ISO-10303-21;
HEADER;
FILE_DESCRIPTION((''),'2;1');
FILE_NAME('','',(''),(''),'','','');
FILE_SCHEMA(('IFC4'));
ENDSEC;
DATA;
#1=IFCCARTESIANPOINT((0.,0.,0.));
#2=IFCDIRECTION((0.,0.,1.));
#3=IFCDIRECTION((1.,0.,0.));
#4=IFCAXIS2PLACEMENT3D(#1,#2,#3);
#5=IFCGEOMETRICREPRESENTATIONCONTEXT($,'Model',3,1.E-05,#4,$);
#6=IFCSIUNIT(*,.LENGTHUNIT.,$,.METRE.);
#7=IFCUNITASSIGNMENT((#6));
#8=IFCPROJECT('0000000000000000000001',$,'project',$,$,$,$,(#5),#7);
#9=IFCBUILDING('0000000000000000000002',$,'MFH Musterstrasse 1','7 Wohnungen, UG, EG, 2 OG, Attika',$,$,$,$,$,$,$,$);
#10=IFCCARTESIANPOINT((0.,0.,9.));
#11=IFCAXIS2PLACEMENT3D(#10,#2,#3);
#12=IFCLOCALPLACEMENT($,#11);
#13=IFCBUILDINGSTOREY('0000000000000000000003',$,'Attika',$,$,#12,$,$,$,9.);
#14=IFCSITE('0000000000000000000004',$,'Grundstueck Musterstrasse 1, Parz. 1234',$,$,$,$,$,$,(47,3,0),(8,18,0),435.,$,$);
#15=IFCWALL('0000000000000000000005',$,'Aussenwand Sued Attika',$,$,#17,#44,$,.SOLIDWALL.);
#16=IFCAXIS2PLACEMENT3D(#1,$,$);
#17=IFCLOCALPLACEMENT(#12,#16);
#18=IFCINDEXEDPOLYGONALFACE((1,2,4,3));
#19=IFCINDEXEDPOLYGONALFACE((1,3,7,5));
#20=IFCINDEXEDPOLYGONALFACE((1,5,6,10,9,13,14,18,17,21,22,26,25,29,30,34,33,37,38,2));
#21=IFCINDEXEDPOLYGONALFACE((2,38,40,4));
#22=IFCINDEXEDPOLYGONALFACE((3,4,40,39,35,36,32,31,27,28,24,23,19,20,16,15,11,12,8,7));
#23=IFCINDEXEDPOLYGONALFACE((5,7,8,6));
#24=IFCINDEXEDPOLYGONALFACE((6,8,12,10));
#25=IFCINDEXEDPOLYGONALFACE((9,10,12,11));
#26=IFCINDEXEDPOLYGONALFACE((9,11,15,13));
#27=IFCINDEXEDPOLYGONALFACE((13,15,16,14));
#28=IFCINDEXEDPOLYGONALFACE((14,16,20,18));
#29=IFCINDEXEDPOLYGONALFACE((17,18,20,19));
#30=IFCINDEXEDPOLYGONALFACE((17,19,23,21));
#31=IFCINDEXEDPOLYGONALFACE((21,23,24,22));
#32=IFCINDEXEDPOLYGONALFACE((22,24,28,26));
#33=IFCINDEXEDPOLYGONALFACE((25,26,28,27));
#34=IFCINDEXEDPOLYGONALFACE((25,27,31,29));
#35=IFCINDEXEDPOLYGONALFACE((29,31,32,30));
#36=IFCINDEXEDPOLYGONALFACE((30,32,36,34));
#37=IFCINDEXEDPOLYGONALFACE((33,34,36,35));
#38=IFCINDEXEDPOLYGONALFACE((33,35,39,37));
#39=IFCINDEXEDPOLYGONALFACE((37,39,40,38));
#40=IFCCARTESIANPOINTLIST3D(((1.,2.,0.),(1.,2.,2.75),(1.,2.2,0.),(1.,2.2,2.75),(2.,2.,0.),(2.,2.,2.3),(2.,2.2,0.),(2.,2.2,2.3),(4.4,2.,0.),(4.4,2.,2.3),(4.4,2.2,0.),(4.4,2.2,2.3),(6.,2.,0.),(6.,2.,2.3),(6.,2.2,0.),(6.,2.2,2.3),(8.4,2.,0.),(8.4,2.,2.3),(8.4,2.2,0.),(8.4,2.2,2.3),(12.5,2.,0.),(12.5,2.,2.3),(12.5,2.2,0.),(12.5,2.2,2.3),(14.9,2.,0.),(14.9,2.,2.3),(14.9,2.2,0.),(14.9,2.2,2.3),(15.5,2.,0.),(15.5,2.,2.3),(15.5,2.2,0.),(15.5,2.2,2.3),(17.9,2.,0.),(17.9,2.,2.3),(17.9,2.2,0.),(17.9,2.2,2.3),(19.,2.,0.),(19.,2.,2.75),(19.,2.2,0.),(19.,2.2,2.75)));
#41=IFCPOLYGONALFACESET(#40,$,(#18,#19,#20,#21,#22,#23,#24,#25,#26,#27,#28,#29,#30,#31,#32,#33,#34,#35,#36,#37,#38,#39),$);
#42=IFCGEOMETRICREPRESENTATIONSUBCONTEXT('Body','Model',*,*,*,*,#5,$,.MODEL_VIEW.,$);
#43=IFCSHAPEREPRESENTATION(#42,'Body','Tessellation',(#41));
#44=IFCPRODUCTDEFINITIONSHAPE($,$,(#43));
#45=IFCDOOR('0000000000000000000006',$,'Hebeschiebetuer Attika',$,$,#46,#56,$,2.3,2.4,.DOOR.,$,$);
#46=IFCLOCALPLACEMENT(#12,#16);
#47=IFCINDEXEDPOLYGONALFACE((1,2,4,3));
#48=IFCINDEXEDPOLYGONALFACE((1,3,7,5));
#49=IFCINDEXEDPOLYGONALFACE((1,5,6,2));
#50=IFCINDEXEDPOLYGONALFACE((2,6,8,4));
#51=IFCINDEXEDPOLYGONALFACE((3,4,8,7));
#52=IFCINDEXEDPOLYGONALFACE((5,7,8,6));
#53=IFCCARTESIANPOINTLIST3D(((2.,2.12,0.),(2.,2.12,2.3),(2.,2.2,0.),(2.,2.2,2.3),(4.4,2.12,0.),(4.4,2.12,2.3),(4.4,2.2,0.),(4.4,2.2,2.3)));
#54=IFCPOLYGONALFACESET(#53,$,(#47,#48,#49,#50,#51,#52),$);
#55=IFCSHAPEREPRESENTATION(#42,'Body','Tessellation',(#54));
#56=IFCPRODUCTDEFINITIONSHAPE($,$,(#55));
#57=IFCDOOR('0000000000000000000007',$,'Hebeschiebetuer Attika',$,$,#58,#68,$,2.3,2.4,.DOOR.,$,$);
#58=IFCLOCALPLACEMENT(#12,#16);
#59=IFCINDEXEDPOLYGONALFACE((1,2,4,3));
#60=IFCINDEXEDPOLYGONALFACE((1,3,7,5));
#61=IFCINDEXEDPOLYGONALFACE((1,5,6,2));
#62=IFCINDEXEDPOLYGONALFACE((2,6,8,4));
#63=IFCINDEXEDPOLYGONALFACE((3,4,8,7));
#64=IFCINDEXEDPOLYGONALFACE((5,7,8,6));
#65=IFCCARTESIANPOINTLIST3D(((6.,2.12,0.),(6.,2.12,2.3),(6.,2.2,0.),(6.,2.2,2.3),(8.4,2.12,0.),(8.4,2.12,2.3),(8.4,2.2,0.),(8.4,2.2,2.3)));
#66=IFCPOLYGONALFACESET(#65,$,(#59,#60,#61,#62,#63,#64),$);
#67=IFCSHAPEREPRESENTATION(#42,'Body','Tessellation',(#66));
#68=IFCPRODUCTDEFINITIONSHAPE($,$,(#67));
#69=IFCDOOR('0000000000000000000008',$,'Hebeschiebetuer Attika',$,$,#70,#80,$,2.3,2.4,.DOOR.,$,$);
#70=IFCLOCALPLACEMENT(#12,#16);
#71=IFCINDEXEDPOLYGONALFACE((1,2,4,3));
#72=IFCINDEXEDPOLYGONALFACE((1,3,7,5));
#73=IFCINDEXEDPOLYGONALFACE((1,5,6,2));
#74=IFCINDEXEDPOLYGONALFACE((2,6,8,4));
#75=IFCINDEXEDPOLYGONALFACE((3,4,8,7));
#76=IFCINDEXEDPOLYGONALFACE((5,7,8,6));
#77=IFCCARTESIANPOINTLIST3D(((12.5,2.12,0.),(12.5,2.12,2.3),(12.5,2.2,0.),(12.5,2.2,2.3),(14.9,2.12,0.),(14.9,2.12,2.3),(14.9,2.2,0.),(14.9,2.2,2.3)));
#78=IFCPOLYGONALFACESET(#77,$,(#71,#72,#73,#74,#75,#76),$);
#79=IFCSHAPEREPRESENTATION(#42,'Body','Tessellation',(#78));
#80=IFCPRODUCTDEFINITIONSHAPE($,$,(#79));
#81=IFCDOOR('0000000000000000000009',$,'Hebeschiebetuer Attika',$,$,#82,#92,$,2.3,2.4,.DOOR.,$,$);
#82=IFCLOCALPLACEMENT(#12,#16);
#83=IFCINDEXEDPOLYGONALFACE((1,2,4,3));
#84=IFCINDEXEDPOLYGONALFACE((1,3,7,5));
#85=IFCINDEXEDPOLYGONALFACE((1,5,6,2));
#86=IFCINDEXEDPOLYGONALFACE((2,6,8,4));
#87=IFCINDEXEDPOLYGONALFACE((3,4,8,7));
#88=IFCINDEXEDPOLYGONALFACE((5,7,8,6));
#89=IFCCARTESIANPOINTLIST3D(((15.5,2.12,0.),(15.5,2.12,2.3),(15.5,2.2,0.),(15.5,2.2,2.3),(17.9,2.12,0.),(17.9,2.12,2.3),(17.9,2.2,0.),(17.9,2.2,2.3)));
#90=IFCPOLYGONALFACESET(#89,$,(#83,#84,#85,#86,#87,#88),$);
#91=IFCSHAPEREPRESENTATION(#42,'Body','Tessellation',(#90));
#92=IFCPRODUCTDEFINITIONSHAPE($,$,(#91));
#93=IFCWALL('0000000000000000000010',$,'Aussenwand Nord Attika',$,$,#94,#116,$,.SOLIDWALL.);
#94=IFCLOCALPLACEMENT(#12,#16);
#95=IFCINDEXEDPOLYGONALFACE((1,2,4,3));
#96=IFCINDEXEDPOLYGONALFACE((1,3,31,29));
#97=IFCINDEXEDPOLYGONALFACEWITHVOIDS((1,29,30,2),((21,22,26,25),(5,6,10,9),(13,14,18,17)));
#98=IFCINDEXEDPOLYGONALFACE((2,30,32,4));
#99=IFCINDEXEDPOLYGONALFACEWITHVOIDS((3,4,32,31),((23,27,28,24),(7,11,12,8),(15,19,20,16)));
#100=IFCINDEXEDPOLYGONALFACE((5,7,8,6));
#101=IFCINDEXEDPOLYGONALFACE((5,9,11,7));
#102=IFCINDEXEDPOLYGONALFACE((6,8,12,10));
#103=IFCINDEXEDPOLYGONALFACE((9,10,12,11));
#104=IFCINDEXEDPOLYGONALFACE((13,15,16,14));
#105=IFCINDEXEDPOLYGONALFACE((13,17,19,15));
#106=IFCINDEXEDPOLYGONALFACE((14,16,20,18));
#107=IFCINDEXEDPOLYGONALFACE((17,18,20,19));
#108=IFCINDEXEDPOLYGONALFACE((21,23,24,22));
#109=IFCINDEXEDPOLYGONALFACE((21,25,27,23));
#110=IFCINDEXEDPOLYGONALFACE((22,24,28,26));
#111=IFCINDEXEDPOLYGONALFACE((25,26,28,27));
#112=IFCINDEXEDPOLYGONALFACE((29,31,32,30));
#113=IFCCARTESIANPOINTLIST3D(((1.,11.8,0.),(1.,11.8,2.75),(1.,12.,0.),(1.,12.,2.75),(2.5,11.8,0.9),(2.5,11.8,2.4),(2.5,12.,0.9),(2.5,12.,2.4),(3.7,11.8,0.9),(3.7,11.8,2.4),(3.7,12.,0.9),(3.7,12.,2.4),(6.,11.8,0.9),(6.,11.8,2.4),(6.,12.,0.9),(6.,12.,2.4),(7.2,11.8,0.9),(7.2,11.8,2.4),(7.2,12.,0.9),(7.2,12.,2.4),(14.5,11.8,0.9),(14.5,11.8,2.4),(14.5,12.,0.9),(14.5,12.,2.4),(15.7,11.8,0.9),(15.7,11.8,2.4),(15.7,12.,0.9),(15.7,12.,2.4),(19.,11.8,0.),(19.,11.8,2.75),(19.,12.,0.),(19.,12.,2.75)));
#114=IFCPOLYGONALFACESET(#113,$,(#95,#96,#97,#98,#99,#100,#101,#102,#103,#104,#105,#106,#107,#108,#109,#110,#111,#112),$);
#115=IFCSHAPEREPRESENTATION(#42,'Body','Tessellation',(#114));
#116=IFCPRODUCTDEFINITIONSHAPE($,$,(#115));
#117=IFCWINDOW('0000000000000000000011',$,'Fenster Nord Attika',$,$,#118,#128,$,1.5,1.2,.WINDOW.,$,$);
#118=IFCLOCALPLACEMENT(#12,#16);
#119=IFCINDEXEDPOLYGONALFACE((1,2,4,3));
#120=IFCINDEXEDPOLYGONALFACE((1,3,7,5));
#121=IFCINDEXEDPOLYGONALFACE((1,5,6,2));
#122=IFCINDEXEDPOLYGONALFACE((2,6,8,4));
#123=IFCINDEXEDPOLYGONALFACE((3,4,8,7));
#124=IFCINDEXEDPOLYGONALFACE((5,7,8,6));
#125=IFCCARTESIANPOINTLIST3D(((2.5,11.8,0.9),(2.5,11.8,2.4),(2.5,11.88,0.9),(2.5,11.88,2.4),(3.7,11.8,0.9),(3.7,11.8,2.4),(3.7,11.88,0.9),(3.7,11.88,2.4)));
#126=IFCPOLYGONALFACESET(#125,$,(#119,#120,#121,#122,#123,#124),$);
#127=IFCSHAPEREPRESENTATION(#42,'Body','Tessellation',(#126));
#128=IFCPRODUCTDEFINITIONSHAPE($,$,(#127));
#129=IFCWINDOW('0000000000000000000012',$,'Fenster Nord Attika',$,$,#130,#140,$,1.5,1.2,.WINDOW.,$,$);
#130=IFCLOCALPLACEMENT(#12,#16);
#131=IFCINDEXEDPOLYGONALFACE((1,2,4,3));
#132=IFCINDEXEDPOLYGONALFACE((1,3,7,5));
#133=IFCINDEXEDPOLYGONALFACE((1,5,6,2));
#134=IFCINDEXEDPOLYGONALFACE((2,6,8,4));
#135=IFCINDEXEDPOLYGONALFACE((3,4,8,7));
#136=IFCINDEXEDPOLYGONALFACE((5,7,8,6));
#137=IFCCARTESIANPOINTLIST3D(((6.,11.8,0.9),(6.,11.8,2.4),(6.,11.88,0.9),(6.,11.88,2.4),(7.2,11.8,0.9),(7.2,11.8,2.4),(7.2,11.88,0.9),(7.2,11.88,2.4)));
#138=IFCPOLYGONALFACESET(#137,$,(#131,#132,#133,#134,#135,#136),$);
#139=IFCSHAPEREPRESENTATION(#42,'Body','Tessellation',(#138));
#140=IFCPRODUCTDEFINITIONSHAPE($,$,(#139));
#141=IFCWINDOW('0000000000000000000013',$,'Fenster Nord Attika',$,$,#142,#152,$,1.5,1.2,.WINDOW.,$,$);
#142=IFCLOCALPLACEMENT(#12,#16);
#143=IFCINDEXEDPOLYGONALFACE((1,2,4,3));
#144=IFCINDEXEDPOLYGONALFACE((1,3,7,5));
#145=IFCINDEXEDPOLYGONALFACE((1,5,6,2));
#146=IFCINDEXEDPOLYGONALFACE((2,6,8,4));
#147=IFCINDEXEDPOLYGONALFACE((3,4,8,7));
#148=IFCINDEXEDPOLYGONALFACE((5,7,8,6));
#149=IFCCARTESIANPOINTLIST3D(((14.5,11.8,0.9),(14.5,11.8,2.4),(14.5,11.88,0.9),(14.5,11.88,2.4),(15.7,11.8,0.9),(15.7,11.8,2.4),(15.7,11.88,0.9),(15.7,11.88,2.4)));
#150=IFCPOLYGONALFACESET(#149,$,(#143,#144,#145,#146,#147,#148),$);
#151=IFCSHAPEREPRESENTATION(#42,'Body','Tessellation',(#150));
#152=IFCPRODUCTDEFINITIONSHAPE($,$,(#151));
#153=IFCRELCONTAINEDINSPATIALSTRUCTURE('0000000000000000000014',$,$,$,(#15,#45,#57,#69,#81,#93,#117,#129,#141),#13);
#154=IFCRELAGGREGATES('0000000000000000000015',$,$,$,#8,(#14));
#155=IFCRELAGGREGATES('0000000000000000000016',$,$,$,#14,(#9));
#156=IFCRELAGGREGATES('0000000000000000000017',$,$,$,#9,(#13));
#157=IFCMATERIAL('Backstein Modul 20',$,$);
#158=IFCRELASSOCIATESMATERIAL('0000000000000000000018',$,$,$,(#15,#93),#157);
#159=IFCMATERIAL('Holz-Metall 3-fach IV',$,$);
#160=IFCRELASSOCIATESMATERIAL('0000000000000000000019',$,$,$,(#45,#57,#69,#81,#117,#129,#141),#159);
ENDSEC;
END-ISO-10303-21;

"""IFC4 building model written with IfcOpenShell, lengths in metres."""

from ifc_helpers import new_model, si_unit, frame, frame_2d, origin_with_axes, place, context, subcontext, project, spatial, rectangle, extrude, material, element, fill, save


model = new_model("IFC4")

# Units and contexts
model_context = context("Model", 3, precision=1e-05, world=origin_with_axes())
body_context = subcontext(model_context, "Body", "Model", "MODEL_VIEW")
ifc_project = project(units=[si_unit("LENGTHUNIT", "METRE")], contexts=[model_context])

# Site, building, storey
site = spatial("IfcSite", under=ifc_project, Name="Grundstueck Musterstrasse 1, Parz. 1234", RefLatitude=(47, 3, 0), RefLongitude=(8, 18, 0), RefElevation=435.0)
building = spatial("IfcBuilding", under=site, Name="MFH Musterstrasse 1", Description="7 Wohnungen, UG, EG, 2 OG, Attika")
storey_placement = place(None, frame((0.0, 0.0, 9.0), z_axis=(0.0, 0.0, 1.0), x_axis=(1.0, 0.0, 0.0)))
storey = spatial("IfcBuildingStorey", under=building, at=storey_placement, Name="Attika", Elevation=9.0)

# Wall, openings, doors
ifc_material_1 = material(Name="Backstein Modul 20")
wall_1_placement = place(storey_placement, frame((1.0, 2.0, 0.0), z_axis=(0.0, 0.0, 1.0), x_axis=(1.0, 0.0, 0.0)))
wall_1 = element("IfcWall", 1, at=wall_1_placement, inside=storey, material=ifc_material_1, Name="Aussenwand Sued Attika", PredefinedType="SOLIDWALL", context=body_context, shape_type="SweptSolid", body=[
    extrude(rectangle(XDim=18.0, YDim=0.2, at=frame_2d((9.0, 0.1))), origin_with_axes(), (0.0, 0.0, 1.0), 2.75),
])
opening_1_placement = place(wall_1_placement, frame((1.0, -0.21, 0.0), z_axis=(0.0, 0.0, 1.0), x_axis=(1.0, 0.0, 0.0)))
opening_1 = element("IfcOpeningElement", 2, at=opening_1_placement, cuts=wall_1, context=body_context, shape_type="SweptSolid", body=[
    extrude(rectangle(XDim=2.4, YDim=0.42, at=frame_2d((1.2, 0.21))), origin_with_axes(), (0.0, 0.0, 1.0), 2.3),
])
opening_2_placement = place(wall_1_placement, frame((5.0, -0.21, 0.0), z_axis=(0.0, 0.0, 1.0), x_axis=(1.0, 0.0, 0.0)))
opening_2 = element("IfcOpeningElement", 3, at=opening_2_placement, cuts=wall_1, context=body_context, shape_type="SweptSolid", body=[
    extrude(rectangle(XDim=2.4, YDim=0.42, at=frame_2d((1.2, 0.21))), origin_with_axes(), (0.0, 0.0, 1.0), 2.3),
])
opening_3_placement = place(wall_1_placement, frame((11.5, -0.21, 0.0), z_axis=(0.0, 0.0, 1.0), x_axis=(1.0, 0.0, 0.0)))
opening_3 = element("IfcOpeningElement", 4, at=opening_3_placement, cuts=wall_1, context=body_context, shape_type="SweptSolid", body=[
    extrude(rectangle(XDim=2.4, YDim=0.42, at=frame_2d((1.2, 0.21))), origin_with_axes(), (0.0, 0.0, 1.0), 2.3),
])
opening_4_placement = place(wall_1_placement, frame((14.5, -0.21, 0.0), z_axis=(0.0, 0.0, 1.0), x_axis=(1.0, 0.0, 0.0)))
opening_4 = element("IfcOpeningElement", 5, at=opening_4_placement, cuts=wall_1, context=body_context, shape_type="SweptSolid", body=[
    extrude(rectangle(XDim=2.4, YDim=0.42, at=frame_2d((1.2, 0.21))), origin_with_axes(), (0.0, 0.0, 1.0), 2.3),
])
ifc_material_2 = material(Name="Holz-Metall 3-fach IV")
door_1_placement = place(storey_placement, frame((2.0, 2.12, 0.0), z_axis=(0.0, 0.0, 1.0), x_axis=(1.0, 0.0, 0.0)))
door_1 = element("IfcDoor", 6, at=door_1_placement, inside=storey, material=ifc_material_2, Name="Hebeschiebetuer Attika", OverallHeight=2.3, OverallWidth=2.4, PredefinedType="DOOR", context=body_context, shape_type="SweptSolid", body=[
    extrude(rectangle(XDim=2.4, YDim=0.08, at=frame_2d((1.2, 0.04))), origin_with_axes(), (0.0, 0.0, 1.0), 2.3),
])
fill(opening_1, door_1)
door_2_placement = place(storey_placement, frame((6.0, 2.12, 0.0), z_axis=(0.0, 0.0, 1.0), x_axis=(1.0, 0.0, 0.0)))
door_2 = element("IfcDoor", 7, at=door_2_placement, inside=storey, material=ifc_material_2, Name="Hebeschiebetuer Attika", OverallHeight=2.3, OverallWidth=2.4, PredefinedType="DOOR", context=body_context, shape_type="SweptSolid", body=[
    extrude(rectangle(XDim=2.4, YDim=0.08, at=frame_2d((1.2, 0.04))), origin_with_axes(), (0.0, 0.0, 1.0), 2.3),
])
fill(opening_2, door_2)
door_3_placement = place(storey_placement, frame((12.5, 2.12, 0.0), z_axis=(0.0, 0.0, 1.0), x_axis=(1.0, 0.0, 0.0)))
door_3 = element("IfcDoor", 8, at=door_3_placement, inside=storey, material=ifc_material_2, Name="Hebeschiebetuer Attika", OverallHeight=2.3, OverallWidth=2.4, PredefinedType="DOOR", context=body_context, shape_type="SweptSolid", body=[
    extrude(rectangle(XDim=2.4, YDim=0.08, at=frame_2d((1.2, 0.04))), origin_with_axes(), (0.0, 0.0, 1.0), 2.3),
])
fill(opening_3, door_3)
door_4_placement = place(storey_placement, frame((15.5, 2.12, 0.0), z_axis=(0.0, 0.0, 1.0), x_axis=(1.0, 0.0, 0.0)))
door_4 = element("IfcDoor", 9, at=door_4_placement, inside=storey, material=ifc_material_2, Name="Hebeschiebetuer Attika", OverallHeight=2.3, OverallWidth=2.4, PredefinedType="DOOR", context=body_context, shape_type="SweptSolid", body=[
    extrude(rectangle(XDim=2.4, YDim=0.08, at=frame_2d((1.2, 0.04))), origin_with_axes(), (0.0, 0.0, 1.0), 2.3),
])
fill(opening_4, door_4)

# Wall, openings, windows
wall_2_placement = place(storey_placement, frame((1.0, 11.8, 0.0), z_axis=(0.0, 0.0, 1.0), x_axis=(1.0, 0.0, 0.0)))
wall_2 = element("IfcWall", 10, at=wall_2_placement, inside=storey, material=ifc_material_1, Name="Aussenwand Nord Attika", PredefinedType="SOLIDWALL", context=body_context, shape_type="SweptSolid", body=[
    extrude(rectangle(XDim=18.0, YDim=0.2, at=frame_2d((9.0, 0.1))), origin_with_axes(), (0.0, 0.0, 1.0), 2.75),
])
opening_5_placement = place(wall_2_placement, frame((1.5, -0.01, 0.9), z_axis=(0.0, 0.0, 1.0), x_axis=(1.0, 0.0, 0.0)))
opening_5 = element("IfcOpeningElement", 11, at=opening_5_placement, cuts=wall_2, context=body_context, shape_type="SweptSolid", body=[
    extrude(rectangle(XDim=1.2, YDim=0.42, at=frame_2d((0.6, 0.21))), origin_with_axes(), (0.0, 0.0, 1.0), 1.5),
])
opening_6_placement = place(wall_2_placement, frame((5.0, -0.01, 0.9), z_axis=(0.0, 0.0, 1.0), x_axis=(1.0, 0.0, 0.0)))
opening_6 = element("IfcOpeningElement", 12, at=opening_6_placement, cuts=wall_2, context=body_context, shape_type="SweptSolid", body=[
    extrude(rectangle(XDim=1.2, YDim=0.42, at=frame_2d((0.6, 0.21))), origin_with_axes(), (0.0, 0.0, 1.0), 1.5),
])
opening_7_placement = place(wall_2_placement, frame((13.5, -0.01, 0.9), z_axis=(0.0, 0.0, 1.0), x_axis=(1.0, 0.0, 0.0)))
opening_7 = element("IfcOpeningElement", 13, at=opening_7_placement, cuts=wall_2, context=body_context, shape_type="SweptSolid", body=[
    extrude(rectangle(XDim=1.2, YDim=0.42, at=frame_2d((0.6, 0.21))), origin_with_axes(), (0.0, 0.0, 1.0), 1.5),
])
window_1_placement = place(storey_placement, frame((2.5, 11.8, 0.9), z_axis=(0.0, 0.0, 1.0), x_axis=(1.0, 0.0, 0.0)))
window_1 = element("IfcWindow", 14, at=window_1_placement, inside=storey, material=ifc_material_2, Name="Fenster Nord Attika", OverallHeight=1.5, OverallWidth=1.2, PredefinedType="WINDOW", context=body_context, shape_type="SweptSolid", body=[
    extrude(rectangle(XDim=1.2, YDim=0.08, at=frame_2d((0.6, 0.04))), origin_with_axes(), (0.0, 0.0, 1.0), 1.5),
])
fill(opening_5, window_1)
window_2_placement = place(storey_placement, frame((6.0, 11.8, 0.9), z_axis=(0.0, 0.0, 1.0), x_axis=(1.0, 0.0, 0.0)))
window_2 = element("IfcWindow", 15, at=window_2_placement, inside=storey, material=ifc_material_2, Name="Fenster Nord Attika", OverallHeight=1.5, OverallWidth=1.2, PredefinedType="WINDOW", context=body_context, shape_type="SweptSolid", body=[
    extrude(rectangle(XDim=1.2, YDim=0.08, at=frame_2d((0.6, 0.04))), origin_with_axes(), (0.0, 0.0, 1.0), 1.5),
])
fill(opening_6, window_2)
window_3_placement = place(storey_placement, frame((14.5, 11.8, 0.9), z_axis=(0.0, 0.0, 1.0), x_axis=(1.0, 0.0, 0.0)))
window_3 = element("IfcWindow", 16, at=window_3_placement, inside=storey, material=ifc_material_2, Name="Fenster Nord Attika", OverallHeight=1.5, OverallWidth=1.2, PredefinedType="WINDOW", context=body_context, shape_type="SweptSolid", body=[
    extrude(rectangle(XDim=1.2, YDim=0.08, at=frame_2d((0.6, 0.04))), origin_with_axes(), (0.0, 0.0, 1.0), 1.5),
])
fill(opening_7, window_3)

save(model, "model.ifc")
